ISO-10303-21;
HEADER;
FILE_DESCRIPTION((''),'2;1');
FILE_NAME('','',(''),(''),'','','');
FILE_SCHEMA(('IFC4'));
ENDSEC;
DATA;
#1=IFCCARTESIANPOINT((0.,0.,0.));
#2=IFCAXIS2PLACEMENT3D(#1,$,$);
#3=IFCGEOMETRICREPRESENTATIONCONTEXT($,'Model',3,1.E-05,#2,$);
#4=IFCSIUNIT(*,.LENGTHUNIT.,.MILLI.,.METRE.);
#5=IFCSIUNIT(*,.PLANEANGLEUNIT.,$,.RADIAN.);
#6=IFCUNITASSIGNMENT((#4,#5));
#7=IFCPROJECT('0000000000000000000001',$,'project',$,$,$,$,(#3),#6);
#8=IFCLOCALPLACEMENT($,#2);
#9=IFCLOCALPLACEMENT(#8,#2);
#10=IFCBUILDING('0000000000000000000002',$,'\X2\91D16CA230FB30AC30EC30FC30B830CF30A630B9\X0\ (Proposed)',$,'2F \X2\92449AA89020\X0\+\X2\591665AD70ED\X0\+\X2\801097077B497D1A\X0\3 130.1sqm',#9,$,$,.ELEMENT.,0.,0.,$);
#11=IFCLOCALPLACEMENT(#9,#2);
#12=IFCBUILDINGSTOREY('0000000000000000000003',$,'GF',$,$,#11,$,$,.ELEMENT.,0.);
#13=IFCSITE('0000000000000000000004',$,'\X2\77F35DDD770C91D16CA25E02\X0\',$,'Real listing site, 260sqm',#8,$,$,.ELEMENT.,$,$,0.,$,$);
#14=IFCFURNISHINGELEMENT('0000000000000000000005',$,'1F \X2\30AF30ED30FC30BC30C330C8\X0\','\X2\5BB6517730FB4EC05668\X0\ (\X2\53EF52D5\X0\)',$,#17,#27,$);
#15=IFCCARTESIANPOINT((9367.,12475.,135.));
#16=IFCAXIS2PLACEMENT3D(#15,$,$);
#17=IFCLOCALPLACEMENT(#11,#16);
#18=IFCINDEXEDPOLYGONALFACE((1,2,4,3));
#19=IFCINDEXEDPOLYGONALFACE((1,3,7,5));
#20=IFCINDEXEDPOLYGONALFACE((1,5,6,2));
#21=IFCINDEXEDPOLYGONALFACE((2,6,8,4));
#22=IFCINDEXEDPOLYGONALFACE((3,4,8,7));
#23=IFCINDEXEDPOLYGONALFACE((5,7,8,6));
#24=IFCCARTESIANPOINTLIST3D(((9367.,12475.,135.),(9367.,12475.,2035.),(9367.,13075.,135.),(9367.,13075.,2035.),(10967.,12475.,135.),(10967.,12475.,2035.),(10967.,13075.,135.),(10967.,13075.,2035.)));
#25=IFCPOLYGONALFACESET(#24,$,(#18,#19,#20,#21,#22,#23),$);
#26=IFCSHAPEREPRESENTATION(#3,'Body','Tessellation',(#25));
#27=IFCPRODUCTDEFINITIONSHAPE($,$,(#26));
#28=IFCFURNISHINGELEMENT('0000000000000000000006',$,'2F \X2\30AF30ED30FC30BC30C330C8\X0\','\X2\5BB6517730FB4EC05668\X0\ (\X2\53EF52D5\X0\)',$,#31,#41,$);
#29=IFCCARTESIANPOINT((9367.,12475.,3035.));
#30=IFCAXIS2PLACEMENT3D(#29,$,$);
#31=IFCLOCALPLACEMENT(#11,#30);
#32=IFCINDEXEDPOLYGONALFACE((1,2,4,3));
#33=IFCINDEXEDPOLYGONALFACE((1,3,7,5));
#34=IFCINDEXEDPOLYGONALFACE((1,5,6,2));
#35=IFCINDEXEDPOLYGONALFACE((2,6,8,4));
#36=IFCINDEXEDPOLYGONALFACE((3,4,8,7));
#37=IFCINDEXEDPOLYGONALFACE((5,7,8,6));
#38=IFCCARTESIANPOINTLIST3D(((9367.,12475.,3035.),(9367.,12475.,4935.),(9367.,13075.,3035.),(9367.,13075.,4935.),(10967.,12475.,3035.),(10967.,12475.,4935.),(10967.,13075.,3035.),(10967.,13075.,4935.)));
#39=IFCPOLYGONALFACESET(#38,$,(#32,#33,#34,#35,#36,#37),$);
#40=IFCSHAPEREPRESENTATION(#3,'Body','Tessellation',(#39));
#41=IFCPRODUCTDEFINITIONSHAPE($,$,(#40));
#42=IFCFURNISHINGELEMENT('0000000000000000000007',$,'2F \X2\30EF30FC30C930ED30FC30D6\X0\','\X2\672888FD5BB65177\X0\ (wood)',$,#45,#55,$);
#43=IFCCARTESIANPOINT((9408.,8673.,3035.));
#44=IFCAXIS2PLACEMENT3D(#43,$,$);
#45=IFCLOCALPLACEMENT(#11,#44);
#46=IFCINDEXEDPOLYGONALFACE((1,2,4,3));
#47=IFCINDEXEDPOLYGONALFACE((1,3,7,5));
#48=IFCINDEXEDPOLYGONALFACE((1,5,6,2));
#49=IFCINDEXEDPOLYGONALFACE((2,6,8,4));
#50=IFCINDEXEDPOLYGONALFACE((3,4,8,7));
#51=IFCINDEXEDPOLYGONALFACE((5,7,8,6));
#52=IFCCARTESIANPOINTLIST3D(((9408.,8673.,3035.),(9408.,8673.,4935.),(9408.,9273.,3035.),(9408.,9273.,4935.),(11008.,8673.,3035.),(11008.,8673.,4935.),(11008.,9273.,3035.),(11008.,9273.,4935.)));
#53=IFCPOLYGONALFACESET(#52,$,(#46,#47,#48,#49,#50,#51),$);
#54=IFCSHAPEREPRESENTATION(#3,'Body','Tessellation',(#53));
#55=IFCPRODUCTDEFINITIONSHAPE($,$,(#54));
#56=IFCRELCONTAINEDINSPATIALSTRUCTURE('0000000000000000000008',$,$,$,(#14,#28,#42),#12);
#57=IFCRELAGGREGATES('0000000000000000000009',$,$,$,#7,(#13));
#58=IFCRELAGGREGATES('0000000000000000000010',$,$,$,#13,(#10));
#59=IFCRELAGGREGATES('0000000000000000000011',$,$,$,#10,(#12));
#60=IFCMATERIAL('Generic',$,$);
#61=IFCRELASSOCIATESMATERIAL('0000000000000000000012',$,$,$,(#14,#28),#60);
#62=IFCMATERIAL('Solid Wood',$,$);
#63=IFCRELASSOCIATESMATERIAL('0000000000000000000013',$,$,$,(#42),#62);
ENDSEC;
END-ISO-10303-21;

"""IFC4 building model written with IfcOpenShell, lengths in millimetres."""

from ifc_helpers import new_model, si_unit, frame, frame_2d, origin, place, context, project, spatial, rectangle, extrude, material, element, save


model = new_model("IFC4")

# Units and contexts
model_context = context("Model", 3, precision=1e-05, world=origin())
ifc_project = project(units=[si_unit("LENGTHUNIT", "METRE", prefix="MILLI"), si_unit("PLANEANGLEUNIT", "RADIAN")], contexts=[model_context])

# Site, building, storey
site_placement = place(None, origin())
site = spatial("IfcSite", under=ifc_project, at=site_placement, Name="石川県金沢市", ObjectType="Real listing site, 260sqm", CompositionType="ELEMENT", RefElevation=0.0)
building_placement = place(site_placement, origin())
building = spatial("IfcBuilding", under=site, at=building_placement, Name="金沢・ガレージハウス (Proposed)", ObjectType="2F 鉄骨造+外断热+耐震等級3 130.1sqm", CompositionType="ELEMENT", ElevationOfRefHeight=0.0, ElevationOfTerrain=0.0)
storey_placement = place(building_placement, origin())
storey = spatial("IfcBuildingStorey", under=building, at=storey_placement, Name="GF", CompositionType="ELEMENT", Elevation=0.0)

# Shared definitions
ifc_material_1 = material(Name="Solid Wood")

# Shared definitions
ifc_material_2 = material(Name="Generic")

# Furnishing elements
furnishing_1_placement = place(storey_placement, frame((9367.0, 12475.0, 135.0)))
element("IfcFurnishingElement", 1, at=furnishing_1_placement, inside=storey, material=ifc_material_2, Name="1F クローゼット", Description="家具・什器 (可動)", context=model_context, shape_type="SweptSolid", body=[
    extrude(rectangle(XDim=1600.0, YDim=600.0, at=frame_2d((800.0, 300.0))), frame((9367.0, 12475.0, 135.0)), (0.0, 0.0, 1.0), 1900.0),
])
furnishing_2_placement = place(storey_placement, frame((9367.0, 12475.0, 3035.0)))
element("IfcFurnishingElement", 2, at=furnishing_2_placement, inside=storey, material=ifc_material_2, Name="2F クローゼット", Description="家具・什器 (可動)", context=model_context, shape_type="SweptSolid", body=[
    extrude(rectangle(XDim=1600.0, YDim=600.0, at=frame_2d((800.0, 300.0))), frame((9367.0, 12475.0, 3035.0)), (0.0, 0.0, 1.0), 1900.0),
])
furnishing_3_placement = place(storey_placement, frame((9408.0, 8673.0, 3035.0)))
element("IfcFurnishingElement", 3, at=furnishing_3_placement, inside=storey, material=ifc_material_1, Name="2F ワードローブ", Description="木製家具 (wood)", context=model_context, shape_type="SweptSolid", body=[
    extrude(rectangle(XDim=1600.0, YDim=600.0, at=frame_2d((800.0, 300.0))), frame((9408.0, 8673.0, 3035.0)), (0.0, 0.0, 1.0), 1900.0),
])

save(model, "model.ifc")
